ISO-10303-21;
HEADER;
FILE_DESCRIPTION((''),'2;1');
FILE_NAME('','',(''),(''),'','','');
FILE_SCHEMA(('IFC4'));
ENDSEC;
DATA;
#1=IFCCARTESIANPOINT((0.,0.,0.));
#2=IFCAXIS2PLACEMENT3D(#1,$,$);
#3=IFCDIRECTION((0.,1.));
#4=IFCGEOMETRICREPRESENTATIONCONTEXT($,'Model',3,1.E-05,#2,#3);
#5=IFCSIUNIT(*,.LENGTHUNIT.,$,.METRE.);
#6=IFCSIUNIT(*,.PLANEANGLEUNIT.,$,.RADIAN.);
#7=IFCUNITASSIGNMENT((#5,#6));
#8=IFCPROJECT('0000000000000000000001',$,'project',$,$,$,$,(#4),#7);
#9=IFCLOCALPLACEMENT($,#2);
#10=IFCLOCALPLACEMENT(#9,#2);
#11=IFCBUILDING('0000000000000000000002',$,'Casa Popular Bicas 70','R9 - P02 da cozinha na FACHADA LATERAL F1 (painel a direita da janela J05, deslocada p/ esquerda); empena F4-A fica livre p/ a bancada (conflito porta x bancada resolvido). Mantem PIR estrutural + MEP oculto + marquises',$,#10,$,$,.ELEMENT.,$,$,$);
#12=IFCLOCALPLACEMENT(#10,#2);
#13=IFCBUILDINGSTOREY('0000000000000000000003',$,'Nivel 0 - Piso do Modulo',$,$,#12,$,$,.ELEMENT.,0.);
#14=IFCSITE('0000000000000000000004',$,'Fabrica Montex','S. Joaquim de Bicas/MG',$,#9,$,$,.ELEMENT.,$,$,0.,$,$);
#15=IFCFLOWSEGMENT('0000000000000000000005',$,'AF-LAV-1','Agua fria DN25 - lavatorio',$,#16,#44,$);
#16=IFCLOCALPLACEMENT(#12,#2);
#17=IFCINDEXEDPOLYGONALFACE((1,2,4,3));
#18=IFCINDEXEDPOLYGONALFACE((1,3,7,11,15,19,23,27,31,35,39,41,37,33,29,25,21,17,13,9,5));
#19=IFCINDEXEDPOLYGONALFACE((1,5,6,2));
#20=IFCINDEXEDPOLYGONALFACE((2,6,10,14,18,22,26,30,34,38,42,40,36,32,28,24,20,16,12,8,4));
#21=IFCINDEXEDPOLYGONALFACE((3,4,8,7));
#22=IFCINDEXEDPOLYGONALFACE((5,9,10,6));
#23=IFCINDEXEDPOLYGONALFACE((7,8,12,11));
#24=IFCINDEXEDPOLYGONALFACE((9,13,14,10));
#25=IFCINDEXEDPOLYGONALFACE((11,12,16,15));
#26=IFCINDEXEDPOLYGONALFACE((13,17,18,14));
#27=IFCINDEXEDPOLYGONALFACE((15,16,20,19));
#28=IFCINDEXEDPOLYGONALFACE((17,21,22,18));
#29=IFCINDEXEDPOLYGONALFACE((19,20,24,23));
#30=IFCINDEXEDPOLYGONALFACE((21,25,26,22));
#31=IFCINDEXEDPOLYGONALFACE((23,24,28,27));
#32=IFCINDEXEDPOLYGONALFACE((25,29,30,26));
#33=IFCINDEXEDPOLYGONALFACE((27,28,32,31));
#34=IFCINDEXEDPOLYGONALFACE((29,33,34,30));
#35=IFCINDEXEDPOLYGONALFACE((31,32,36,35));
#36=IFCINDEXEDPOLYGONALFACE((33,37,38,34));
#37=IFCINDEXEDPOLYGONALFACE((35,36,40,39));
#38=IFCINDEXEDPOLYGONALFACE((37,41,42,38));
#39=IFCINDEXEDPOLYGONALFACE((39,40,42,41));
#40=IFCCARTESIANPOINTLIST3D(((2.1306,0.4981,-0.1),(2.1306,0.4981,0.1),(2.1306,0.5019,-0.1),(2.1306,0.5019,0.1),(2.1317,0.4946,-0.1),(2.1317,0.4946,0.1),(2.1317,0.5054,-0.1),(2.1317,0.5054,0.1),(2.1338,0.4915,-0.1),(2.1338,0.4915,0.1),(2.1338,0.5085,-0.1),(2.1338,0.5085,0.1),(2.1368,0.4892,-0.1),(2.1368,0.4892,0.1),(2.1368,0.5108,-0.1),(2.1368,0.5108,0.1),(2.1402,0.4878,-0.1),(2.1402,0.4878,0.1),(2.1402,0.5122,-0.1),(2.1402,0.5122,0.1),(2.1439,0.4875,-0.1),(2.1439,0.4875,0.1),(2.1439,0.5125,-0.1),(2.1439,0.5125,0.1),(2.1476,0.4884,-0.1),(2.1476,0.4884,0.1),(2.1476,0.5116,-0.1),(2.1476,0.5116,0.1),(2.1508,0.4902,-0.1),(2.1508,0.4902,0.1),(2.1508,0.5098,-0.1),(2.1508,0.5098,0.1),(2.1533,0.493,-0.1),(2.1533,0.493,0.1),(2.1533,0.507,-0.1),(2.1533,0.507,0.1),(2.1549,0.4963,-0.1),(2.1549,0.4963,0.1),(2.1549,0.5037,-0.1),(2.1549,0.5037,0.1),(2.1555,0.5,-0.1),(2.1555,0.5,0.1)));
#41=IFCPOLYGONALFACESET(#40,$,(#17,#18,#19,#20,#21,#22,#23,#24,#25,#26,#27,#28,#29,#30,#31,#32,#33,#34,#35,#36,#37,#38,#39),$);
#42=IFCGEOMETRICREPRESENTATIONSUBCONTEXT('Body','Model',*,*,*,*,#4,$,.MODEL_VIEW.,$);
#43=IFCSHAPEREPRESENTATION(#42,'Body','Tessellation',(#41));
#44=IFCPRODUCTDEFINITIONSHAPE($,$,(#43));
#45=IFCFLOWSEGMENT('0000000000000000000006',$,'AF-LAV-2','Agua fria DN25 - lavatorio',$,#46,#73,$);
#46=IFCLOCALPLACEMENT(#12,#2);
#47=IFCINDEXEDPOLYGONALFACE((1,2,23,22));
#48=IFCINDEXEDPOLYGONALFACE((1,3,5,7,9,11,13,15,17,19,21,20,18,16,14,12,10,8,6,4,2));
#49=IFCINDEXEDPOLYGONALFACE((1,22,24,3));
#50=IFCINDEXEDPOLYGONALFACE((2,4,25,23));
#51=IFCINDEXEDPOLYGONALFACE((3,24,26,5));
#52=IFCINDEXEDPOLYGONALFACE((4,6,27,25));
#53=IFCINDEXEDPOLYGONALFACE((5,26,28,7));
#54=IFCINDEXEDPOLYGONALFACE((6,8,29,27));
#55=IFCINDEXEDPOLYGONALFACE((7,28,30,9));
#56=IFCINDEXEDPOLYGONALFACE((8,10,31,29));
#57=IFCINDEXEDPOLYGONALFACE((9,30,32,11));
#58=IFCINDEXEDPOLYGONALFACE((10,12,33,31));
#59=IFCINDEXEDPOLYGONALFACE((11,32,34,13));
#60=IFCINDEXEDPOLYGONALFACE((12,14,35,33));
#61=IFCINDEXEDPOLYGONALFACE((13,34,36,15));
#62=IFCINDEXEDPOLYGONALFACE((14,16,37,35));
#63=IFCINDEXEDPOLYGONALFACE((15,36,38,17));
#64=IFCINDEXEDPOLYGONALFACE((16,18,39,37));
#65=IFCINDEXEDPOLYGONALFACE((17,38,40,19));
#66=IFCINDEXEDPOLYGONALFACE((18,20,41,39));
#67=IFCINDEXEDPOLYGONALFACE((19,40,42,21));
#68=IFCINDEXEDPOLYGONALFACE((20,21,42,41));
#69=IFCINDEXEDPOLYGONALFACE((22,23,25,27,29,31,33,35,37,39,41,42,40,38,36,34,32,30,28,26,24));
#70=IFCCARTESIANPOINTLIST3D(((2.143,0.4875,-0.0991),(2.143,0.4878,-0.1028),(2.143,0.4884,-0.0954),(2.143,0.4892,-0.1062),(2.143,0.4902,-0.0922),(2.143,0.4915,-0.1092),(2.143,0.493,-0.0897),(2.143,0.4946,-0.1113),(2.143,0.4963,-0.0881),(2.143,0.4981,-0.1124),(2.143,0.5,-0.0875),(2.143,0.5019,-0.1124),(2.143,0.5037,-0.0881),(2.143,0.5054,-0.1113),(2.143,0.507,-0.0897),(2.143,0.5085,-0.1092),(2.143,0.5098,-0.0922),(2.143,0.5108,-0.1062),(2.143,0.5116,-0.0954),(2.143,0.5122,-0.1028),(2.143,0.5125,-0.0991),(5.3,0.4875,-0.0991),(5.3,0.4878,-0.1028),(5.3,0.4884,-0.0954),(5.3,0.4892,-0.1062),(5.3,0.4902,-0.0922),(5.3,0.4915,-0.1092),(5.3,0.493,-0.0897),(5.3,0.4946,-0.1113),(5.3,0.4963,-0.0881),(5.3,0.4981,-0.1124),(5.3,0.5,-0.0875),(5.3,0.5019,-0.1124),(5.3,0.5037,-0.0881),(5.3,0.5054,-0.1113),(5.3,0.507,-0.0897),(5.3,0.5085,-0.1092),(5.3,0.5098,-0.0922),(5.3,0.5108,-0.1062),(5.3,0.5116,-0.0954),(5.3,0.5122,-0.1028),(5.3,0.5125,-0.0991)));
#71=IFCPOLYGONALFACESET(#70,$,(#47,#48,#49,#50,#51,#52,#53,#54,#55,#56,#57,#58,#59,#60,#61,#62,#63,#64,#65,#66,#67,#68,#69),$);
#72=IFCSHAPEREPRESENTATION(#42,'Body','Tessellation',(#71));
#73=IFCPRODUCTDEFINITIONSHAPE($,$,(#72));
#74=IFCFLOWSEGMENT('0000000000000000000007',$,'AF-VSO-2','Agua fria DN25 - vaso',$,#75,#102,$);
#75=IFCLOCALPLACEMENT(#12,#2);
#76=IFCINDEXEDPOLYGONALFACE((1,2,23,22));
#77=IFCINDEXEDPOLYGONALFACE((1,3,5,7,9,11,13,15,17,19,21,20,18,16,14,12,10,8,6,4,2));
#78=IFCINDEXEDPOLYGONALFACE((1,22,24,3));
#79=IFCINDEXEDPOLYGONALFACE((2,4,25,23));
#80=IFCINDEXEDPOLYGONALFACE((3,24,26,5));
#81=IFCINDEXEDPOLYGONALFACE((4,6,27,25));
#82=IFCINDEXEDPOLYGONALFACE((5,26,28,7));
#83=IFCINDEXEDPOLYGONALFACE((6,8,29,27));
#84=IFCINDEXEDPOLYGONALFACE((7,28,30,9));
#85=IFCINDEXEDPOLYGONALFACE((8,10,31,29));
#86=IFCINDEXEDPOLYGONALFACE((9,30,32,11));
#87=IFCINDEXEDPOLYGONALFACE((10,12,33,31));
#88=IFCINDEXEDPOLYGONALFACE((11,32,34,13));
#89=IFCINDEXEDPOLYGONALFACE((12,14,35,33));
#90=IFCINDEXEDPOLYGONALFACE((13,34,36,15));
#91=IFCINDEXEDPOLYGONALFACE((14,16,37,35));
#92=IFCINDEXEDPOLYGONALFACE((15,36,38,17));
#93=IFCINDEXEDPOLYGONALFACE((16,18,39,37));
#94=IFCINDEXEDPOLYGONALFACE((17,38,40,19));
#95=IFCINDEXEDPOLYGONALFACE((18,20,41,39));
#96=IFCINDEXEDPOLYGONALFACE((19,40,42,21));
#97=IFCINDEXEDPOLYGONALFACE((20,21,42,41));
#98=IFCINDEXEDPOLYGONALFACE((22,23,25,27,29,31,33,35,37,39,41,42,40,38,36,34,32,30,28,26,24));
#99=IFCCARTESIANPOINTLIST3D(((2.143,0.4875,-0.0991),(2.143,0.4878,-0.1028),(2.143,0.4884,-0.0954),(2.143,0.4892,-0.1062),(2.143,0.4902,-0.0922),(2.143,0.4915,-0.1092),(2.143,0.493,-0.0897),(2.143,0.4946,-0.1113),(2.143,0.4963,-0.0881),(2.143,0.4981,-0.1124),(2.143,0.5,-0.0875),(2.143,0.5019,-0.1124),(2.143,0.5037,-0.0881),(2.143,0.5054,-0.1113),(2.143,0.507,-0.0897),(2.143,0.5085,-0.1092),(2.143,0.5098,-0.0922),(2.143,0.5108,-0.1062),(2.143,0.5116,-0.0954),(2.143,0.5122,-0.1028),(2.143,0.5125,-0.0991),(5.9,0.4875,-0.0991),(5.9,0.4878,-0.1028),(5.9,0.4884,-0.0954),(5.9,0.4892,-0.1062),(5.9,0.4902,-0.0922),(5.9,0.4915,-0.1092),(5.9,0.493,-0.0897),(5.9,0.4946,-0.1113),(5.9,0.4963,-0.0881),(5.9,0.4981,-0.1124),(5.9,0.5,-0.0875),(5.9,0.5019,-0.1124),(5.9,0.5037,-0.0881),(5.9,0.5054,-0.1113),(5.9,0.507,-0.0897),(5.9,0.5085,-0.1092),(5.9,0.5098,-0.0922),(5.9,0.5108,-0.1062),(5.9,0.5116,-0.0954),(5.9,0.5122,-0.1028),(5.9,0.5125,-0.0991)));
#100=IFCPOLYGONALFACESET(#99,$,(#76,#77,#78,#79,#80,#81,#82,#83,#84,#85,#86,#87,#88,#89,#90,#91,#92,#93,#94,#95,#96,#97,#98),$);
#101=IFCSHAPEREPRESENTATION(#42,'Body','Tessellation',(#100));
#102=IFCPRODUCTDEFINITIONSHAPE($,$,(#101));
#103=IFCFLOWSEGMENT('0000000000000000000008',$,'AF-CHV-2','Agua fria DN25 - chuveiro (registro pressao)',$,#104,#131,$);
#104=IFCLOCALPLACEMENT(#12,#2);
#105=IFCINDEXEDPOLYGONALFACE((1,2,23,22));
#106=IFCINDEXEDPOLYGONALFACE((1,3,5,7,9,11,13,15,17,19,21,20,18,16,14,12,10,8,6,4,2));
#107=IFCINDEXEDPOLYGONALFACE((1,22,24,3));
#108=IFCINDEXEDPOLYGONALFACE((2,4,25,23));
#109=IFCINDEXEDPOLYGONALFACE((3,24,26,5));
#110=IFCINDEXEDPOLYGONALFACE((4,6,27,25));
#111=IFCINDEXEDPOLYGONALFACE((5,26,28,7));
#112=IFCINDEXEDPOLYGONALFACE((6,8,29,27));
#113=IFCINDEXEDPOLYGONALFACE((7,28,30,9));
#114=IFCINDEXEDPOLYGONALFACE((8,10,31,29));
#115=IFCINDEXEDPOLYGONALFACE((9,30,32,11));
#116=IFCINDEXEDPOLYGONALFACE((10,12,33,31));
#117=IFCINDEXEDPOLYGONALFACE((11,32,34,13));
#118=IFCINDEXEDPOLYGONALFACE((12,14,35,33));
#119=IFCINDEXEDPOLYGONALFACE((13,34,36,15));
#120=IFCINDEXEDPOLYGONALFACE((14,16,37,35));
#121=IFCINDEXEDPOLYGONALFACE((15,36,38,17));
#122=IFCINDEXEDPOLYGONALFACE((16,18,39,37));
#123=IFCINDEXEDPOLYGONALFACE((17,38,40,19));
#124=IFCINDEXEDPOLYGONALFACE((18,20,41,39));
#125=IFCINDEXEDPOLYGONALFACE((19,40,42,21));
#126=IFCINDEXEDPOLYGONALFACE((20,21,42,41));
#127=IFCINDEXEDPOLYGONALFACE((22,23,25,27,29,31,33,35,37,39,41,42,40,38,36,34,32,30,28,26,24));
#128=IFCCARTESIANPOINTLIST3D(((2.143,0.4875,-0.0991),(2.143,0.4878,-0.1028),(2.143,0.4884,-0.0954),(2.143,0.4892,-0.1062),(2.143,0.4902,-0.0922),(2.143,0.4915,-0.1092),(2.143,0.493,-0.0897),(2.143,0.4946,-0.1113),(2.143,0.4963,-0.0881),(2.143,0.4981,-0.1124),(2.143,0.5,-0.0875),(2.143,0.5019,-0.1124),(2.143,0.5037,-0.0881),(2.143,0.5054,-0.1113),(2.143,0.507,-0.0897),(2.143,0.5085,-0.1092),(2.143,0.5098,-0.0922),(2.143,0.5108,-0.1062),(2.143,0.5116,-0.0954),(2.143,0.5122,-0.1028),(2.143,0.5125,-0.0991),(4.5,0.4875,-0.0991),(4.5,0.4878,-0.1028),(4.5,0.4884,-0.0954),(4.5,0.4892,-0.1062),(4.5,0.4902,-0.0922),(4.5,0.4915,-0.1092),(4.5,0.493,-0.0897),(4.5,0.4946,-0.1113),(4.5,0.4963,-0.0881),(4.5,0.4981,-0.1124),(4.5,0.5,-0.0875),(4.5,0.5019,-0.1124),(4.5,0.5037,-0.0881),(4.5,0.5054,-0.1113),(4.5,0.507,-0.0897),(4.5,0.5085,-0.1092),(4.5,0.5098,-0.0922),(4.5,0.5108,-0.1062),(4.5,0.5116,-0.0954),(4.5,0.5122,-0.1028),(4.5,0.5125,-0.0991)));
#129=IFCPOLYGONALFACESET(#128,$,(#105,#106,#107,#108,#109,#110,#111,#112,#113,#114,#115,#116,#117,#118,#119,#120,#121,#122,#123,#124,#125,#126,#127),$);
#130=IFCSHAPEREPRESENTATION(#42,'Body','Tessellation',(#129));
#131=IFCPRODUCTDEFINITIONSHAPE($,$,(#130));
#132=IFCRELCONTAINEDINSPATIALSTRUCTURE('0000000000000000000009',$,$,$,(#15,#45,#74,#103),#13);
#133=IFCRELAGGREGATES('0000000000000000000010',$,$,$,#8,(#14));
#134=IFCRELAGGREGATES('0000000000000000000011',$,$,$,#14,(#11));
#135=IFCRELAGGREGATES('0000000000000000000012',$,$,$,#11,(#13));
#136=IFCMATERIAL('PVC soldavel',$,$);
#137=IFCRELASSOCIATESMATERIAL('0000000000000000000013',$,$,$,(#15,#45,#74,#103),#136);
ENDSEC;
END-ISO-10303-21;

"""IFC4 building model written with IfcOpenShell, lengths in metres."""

from ifc_helpers import new_model, si_unit, direction, frame, origin, origin_2d, place, context, subcontext, project, spatial, circle, extrude, material, element, save


model = new_model("IFC4")

# Units and contexts
model_context = context("Model", 3, precision=1e-05, world=origin(), true_north=direction((0.0, 1.0)))
body_context = subcontext(model_context, "Body", "Model", "MODEL_VIEW")
ifc_project = project(units=[si_unit("LENGTHUNIT", "METRE"), si_unit("PLANEANGLEUNIT", "RADIAN")], contexts=[model_context])

# Site, building, storey
site_placement = place(None, origin())
site = spatial("IfcSite", under=ifc_project, at=site_placement, Name="Fabrica Montex", Description="S. Joaquim de Bicas/MG", CompositionType="ELEMENT", RefElevation=0.0)
building_placement = place(site_placement, origin())
building = spatial("IfcBuilding", under=site, at=building_placement, Name="Casa Popular Bicas 70", Description="R9 - P02 da cozinha na FACHADA LATERAL F1 (painel a direita da janela J05, deslocada p/ esquerda); empena F4-A fica livre p/ a bancada (conflito porta x bancada resolvido). Mantem PIR estrutural + MEP oculto + marquises", CompositionType="ELEMENT")
storey_placement = place(building_placement, origin())
storey = spatial("IfcBuildingStorey", under=building, at=storey_placement, Name="Nivel 0 - Piso do Modulo", CompositionType="ELEMENT", Elevation=0.0)

# Flow segments
ifc_material_1 = material(Name="PVC soldavel")
flow_segment_1_placement = place(storey_placement, frame((2.143, 0.5, 0.1), z_axis=(0.0, 0.0, -1.0), x_axis=(1.0, 0.0, 0.0)))
element("IfcFlowSegment", 1, at=flow_segment_1_placement, inside=storey, material=ifc_material_1, Name="AF-LAV-1", Description="Agua fria DN25 - lavatorio", context=body_context, shape_type="SweptSolid", body=[
    extrude(circle(Radius=0.0125, at=origin_2d()), origin(), (0.0, 0.0, 1.0), 0.2),
])
flow_segment_2_placement = place(storey_placement, frame((2.143, 0.5, -0.1), z_axis=(1.0, 0.0, 0.0), x_axis=(0.0, 0.0, 1.0)))
element("IfcFlowSegment", 2, at=flow_segment_2_placement, inside=storey, material=ifc_material_1, Name="AF-LAV-2", Description="Agua fria DN25 - lavatorio", context=body_context, shape_type="SweptSolid", body=[
    extrude(circle(Radius=0.0125, at=origin_2d()), origin(), (0.0, 0.0, 1.0), 3.157),
])
flow_segment_3_placement = place(storey_placement, frame((2.143, 0.5, -0.1), z_axis=(1.0, 0.0, 0.0), x_axis=(0.0, 0.0, 1.0)))
element("IfcFlowSegment", 3, at=flow_segment_3_placement, inside=storey, material=ifc_material_1, Name="AF-VSO-2", Description="Agua fria DN25 - vaso", context=body_context, shape_type="SweptSolid", body=[
    extrude(circle(Radius=0.0125, at=origin_2d()), origin(), (0.0, 0.0, 1.0), 3.757),
])
flow_segment_4_placement = place(storey_placement, frame((2.143, 0.5, -0.1), z_axis=(1.0, 0.0, 0.0), x_axis=(0.0, 0.0, 1.0)))
element("IfcFlowSegment", 4, at=flow_segment_4_placement, inside=storey, material=ifc_material_1, Name="AF-CHV-2", Description="Agua fria DN25 - chuveiro (registro pressao)", context=body_context, shape_type="SweptSolid", body=[
    extrude(circle(Radius=0.0125, at=origin_2d()), origin(), (0.0, 0.0, 1.0), 2.357),
])

save(model, "model.ifc")
